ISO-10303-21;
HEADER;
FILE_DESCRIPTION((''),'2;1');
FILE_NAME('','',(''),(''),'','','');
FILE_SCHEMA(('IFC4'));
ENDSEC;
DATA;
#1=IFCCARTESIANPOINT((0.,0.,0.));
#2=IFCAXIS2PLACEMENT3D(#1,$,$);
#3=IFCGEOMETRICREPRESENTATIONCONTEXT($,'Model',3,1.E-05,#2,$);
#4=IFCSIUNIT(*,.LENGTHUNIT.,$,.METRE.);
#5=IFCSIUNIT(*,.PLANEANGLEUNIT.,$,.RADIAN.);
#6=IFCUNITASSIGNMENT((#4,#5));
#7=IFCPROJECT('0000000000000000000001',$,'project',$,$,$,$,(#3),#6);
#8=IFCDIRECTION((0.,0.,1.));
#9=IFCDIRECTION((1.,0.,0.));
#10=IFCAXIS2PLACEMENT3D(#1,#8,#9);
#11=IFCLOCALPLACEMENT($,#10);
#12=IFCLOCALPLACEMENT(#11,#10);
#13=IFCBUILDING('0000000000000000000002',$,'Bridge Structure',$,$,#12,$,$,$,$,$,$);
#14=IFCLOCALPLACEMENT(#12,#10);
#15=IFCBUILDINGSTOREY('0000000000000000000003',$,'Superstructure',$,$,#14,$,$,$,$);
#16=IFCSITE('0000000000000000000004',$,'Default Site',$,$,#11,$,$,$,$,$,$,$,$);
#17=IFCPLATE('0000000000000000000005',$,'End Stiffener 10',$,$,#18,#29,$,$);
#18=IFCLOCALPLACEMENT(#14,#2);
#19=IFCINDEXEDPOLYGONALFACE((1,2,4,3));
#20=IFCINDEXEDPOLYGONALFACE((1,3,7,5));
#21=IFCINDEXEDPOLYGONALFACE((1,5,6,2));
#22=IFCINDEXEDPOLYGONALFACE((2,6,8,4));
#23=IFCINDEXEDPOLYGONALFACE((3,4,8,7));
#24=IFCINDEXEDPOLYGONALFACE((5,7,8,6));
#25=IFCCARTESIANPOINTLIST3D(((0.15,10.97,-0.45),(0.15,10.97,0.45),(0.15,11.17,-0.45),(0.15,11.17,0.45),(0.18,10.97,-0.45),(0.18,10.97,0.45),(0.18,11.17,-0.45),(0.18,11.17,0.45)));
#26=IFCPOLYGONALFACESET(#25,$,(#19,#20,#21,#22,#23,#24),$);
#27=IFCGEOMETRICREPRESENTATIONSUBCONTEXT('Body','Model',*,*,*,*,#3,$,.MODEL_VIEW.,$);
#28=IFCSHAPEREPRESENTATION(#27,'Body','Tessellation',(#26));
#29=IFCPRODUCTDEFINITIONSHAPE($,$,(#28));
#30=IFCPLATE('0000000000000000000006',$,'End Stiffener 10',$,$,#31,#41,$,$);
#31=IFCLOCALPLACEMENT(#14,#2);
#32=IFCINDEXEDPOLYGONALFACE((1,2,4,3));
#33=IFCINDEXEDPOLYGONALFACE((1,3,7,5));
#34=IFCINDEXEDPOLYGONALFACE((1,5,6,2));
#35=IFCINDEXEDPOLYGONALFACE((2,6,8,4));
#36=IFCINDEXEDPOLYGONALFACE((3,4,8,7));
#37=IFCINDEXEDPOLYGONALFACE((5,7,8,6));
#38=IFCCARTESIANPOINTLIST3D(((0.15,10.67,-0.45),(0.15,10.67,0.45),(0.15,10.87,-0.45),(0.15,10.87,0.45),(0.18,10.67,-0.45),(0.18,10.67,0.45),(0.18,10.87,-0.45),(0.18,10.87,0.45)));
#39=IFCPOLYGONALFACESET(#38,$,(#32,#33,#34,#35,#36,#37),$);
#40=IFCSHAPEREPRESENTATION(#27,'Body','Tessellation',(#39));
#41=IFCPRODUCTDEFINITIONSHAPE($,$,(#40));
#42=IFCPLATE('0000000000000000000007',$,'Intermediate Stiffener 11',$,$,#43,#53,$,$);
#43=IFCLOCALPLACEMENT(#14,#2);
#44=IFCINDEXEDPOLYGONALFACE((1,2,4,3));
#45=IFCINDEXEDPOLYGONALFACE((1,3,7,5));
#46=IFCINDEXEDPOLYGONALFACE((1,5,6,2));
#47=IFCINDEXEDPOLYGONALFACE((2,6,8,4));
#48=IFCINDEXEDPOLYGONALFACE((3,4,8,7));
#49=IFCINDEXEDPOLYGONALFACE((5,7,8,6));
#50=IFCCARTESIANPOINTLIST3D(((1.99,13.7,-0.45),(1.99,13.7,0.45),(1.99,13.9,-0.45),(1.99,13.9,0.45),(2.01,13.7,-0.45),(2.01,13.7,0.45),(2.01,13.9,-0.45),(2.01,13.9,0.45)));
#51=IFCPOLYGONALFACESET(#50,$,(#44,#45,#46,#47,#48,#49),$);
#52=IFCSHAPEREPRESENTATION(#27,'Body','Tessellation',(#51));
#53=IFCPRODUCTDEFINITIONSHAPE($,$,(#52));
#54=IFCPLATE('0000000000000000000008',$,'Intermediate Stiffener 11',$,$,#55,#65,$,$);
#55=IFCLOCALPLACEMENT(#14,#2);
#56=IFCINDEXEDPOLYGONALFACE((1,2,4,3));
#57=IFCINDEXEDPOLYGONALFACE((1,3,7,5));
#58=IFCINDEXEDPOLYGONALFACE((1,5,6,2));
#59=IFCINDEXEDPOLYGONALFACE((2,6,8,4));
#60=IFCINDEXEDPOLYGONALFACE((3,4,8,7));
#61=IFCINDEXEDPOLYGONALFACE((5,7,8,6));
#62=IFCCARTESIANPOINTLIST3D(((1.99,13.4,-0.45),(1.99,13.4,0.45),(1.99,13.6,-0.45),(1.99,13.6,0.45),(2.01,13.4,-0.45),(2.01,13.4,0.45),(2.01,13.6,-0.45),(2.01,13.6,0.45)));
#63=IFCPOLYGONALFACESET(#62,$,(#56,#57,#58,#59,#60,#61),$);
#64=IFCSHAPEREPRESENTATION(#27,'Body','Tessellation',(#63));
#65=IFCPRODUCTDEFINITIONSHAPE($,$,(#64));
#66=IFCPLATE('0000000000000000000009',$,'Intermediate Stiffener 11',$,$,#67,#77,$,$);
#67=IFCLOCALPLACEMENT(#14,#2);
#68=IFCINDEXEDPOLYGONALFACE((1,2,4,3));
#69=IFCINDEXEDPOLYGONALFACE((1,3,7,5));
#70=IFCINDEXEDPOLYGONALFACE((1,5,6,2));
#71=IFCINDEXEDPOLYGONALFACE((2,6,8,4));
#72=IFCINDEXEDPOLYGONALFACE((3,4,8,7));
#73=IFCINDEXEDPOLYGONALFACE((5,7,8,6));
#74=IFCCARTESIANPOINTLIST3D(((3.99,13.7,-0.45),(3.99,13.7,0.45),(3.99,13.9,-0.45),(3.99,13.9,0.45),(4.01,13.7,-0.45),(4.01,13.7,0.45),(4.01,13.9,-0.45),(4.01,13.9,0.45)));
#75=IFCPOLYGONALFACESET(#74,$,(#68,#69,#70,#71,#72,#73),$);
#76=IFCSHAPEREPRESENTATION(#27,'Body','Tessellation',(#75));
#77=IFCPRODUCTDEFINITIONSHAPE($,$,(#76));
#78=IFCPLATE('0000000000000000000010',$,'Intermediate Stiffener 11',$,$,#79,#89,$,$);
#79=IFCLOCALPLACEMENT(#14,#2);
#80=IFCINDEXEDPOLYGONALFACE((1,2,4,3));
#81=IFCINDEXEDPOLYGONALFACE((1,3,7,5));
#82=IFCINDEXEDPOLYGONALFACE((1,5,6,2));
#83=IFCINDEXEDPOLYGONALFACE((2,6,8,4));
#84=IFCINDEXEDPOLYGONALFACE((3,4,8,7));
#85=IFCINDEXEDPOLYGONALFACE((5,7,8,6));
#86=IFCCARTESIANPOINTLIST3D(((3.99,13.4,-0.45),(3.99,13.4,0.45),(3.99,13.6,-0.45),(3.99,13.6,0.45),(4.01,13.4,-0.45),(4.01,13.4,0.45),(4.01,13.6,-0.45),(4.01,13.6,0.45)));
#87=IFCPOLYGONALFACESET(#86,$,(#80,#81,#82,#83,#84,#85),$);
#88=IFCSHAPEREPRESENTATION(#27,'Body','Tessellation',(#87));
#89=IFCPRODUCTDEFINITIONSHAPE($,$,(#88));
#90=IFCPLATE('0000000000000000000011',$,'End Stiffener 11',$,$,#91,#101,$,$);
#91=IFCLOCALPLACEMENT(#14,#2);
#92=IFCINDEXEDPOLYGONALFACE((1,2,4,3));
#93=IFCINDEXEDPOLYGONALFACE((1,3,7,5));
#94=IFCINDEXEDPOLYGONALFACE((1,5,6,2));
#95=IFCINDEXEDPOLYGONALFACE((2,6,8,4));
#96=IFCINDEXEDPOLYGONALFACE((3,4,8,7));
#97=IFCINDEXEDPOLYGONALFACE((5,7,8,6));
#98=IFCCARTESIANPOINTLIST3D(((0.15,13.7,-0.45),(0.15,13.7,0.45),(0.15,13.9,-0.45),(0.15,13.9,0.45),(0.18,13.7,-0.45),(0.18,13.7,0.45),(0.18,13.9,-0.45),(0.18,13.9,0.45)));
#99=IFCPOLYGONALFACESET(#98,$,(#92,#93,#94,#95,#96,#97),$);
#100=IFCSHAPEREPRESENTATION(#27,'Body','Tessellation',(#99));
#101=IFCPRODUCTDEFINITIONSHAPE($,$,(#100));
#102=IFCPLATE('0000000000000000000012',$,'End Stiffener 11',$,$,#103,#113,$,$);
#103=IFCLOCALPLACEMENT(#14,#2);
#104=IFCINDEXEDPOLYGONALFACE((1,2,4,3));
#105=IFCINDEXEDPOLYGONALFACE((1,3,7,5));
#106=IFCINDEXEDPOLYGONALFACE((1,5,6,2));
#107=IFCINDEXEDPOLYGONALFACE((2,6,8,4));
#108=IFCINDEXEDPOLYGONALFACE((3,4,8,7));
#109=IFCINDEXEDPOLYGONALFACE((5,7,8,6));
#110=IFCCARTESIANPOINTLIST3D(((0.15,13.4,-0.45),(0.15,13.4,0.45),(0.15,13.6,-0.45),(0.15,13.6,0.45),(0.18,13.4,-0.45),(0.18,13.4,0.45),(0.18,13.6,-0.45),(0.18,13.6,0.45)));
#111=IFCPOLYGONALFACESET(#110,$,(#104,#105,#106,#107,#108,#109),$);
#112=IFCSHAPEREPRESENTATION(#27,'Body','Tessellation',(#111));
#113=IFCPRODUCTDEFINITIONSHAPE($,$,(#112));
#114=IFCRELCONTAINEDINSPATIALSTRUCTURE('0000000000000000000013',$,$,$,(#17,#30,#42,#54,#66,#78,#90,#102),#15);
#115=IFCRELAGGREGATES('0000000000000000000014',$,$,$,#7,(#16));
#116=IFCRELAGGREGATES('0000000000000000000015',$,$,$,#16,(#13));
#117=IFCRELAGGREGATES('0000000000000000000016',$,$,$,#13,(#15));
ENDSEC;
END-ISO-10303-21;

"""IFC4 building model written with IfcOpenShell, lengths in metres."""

from ifc_helpers import new_model, si_unit, frame, origin, origin_with_axes, origin_2d_with_axis, place, context, subcontext, project, spatial, rectangle, extrude, element, save


model = new_model("IFC4")

# Units and contexts
model_context = context("Model", 3, precision=1e-05, world=origin())
body_context = subcontext(model_context, "Body", "Model", "MODEL_VIEW")
ifc_project = project(units=[si_unit("LENGTHUNIT", "METRE"), si_unit("PLANEANGLEUNIT", "RADIAN")], contexts=[model_context])

# Site, building, storey
site_placement = place(None, origin_with_axes())
site = spatial("IfcSite", under=ifc_project, at=site_placement, Name="Default Site")
building_placement = place(site_placement, origin_with_axes())
building = spatial("IfcBuilding", under=site, at=building_placement, Name="Bridge Structure")
storey_placement = place(building_placement, origin_with_axes())
storey = spatial("IfcBuildingStorey", under=building, at=storey_placement, Name="Superstructure")

# Plates
for number, where, z_axis, x_axis, name in (
    (1, (0.165, 11.07, -0.45), (0.0, 0.0, 1.0), (1.0, 0.0, 0.0), "End Stiffener 10"),
    (2, (0.165, 10.77, -0.45), (0.0, 0.0, 1.0), (1.0, 0.0, 0.0), "End Stiffener 10"),
):
    element("IfcPlate", number, at=place(storey_placement, frame(where, z_axis=z_axis, x_axis=x_axis)), inside=storey, Name=name, context=body_context, shape_type="SweptSolid", body=[
        extrude(rectangle(XDim=0.03, YDim=0.2, at=origin_2d_with_axis()), origin_with_axes(), (0.0, 0.0, 1.0), 0.9),
    ])
for number, where, z_axis, x_axis, name in (
    (3, (2.0, 13.8, -0.45), (0.0, 0.0, 1.0), (1.0, 0.0, 0.0), "Intermediate Stiffener 11"),
    (4, (2.0, 13.5, -0.45), (0.0, 0.0, 1.0), (1.0, 0.0, 0.0), "Intermediate Stiffener 11"),
    (5, (4.0, 13.8, -0.45), (0.0, 0.0, 1.0), (1.0, 0.0, 0.0), "Intermediate Stiffener 11"),
    (6, (4.0, 13.5, -0.45), (0.0, 0.0, 1.0), (1.0, 0.0, 0.0), "Intermediate Stiffener 11"),
):
    element("IfcPlate", number, at=place(storey_placement, frame(where, z_axis=z_axis, x_axis=x_axis)), inside=storey, Name=name, context=body_context, shape_type="SweptSolid", body=[
        extrude(rectangle(XDim=0.02, YDim=0.2, at=origin_2d_with_axis()), origin_with_axes(), (0.0, 0.0, 1.0), 0.9),
    ])
for number, where, z_axis, x_axis, name in (
    (7, (0.165, 13.8, -0.45), (0.0, 0.0, 1.0), (1.0, 0.0, 0.0), "End Stiffener 11"),
    (8, (0.165, 13.5, -0.45), (0.0, 0.0, 1.0), (1.0, 0.0, 0.0), "End Stiffener 11"),
):
    element("IfcPlate", number, at=place(storey_placement, frame(where, z_axis=z_axis, x_axis=x_axis)), inside=storey, Name=name, context=body_context, shape_type="SweptSolid", body=[
        extrude(rectangle(XDim=0.03, YDim=0.2, at=origin_2d_with_axis()), origin_with_axes(), (0.0, 0.0, 1.0), 0.9),
    ])

save(model, "model.ifc")
